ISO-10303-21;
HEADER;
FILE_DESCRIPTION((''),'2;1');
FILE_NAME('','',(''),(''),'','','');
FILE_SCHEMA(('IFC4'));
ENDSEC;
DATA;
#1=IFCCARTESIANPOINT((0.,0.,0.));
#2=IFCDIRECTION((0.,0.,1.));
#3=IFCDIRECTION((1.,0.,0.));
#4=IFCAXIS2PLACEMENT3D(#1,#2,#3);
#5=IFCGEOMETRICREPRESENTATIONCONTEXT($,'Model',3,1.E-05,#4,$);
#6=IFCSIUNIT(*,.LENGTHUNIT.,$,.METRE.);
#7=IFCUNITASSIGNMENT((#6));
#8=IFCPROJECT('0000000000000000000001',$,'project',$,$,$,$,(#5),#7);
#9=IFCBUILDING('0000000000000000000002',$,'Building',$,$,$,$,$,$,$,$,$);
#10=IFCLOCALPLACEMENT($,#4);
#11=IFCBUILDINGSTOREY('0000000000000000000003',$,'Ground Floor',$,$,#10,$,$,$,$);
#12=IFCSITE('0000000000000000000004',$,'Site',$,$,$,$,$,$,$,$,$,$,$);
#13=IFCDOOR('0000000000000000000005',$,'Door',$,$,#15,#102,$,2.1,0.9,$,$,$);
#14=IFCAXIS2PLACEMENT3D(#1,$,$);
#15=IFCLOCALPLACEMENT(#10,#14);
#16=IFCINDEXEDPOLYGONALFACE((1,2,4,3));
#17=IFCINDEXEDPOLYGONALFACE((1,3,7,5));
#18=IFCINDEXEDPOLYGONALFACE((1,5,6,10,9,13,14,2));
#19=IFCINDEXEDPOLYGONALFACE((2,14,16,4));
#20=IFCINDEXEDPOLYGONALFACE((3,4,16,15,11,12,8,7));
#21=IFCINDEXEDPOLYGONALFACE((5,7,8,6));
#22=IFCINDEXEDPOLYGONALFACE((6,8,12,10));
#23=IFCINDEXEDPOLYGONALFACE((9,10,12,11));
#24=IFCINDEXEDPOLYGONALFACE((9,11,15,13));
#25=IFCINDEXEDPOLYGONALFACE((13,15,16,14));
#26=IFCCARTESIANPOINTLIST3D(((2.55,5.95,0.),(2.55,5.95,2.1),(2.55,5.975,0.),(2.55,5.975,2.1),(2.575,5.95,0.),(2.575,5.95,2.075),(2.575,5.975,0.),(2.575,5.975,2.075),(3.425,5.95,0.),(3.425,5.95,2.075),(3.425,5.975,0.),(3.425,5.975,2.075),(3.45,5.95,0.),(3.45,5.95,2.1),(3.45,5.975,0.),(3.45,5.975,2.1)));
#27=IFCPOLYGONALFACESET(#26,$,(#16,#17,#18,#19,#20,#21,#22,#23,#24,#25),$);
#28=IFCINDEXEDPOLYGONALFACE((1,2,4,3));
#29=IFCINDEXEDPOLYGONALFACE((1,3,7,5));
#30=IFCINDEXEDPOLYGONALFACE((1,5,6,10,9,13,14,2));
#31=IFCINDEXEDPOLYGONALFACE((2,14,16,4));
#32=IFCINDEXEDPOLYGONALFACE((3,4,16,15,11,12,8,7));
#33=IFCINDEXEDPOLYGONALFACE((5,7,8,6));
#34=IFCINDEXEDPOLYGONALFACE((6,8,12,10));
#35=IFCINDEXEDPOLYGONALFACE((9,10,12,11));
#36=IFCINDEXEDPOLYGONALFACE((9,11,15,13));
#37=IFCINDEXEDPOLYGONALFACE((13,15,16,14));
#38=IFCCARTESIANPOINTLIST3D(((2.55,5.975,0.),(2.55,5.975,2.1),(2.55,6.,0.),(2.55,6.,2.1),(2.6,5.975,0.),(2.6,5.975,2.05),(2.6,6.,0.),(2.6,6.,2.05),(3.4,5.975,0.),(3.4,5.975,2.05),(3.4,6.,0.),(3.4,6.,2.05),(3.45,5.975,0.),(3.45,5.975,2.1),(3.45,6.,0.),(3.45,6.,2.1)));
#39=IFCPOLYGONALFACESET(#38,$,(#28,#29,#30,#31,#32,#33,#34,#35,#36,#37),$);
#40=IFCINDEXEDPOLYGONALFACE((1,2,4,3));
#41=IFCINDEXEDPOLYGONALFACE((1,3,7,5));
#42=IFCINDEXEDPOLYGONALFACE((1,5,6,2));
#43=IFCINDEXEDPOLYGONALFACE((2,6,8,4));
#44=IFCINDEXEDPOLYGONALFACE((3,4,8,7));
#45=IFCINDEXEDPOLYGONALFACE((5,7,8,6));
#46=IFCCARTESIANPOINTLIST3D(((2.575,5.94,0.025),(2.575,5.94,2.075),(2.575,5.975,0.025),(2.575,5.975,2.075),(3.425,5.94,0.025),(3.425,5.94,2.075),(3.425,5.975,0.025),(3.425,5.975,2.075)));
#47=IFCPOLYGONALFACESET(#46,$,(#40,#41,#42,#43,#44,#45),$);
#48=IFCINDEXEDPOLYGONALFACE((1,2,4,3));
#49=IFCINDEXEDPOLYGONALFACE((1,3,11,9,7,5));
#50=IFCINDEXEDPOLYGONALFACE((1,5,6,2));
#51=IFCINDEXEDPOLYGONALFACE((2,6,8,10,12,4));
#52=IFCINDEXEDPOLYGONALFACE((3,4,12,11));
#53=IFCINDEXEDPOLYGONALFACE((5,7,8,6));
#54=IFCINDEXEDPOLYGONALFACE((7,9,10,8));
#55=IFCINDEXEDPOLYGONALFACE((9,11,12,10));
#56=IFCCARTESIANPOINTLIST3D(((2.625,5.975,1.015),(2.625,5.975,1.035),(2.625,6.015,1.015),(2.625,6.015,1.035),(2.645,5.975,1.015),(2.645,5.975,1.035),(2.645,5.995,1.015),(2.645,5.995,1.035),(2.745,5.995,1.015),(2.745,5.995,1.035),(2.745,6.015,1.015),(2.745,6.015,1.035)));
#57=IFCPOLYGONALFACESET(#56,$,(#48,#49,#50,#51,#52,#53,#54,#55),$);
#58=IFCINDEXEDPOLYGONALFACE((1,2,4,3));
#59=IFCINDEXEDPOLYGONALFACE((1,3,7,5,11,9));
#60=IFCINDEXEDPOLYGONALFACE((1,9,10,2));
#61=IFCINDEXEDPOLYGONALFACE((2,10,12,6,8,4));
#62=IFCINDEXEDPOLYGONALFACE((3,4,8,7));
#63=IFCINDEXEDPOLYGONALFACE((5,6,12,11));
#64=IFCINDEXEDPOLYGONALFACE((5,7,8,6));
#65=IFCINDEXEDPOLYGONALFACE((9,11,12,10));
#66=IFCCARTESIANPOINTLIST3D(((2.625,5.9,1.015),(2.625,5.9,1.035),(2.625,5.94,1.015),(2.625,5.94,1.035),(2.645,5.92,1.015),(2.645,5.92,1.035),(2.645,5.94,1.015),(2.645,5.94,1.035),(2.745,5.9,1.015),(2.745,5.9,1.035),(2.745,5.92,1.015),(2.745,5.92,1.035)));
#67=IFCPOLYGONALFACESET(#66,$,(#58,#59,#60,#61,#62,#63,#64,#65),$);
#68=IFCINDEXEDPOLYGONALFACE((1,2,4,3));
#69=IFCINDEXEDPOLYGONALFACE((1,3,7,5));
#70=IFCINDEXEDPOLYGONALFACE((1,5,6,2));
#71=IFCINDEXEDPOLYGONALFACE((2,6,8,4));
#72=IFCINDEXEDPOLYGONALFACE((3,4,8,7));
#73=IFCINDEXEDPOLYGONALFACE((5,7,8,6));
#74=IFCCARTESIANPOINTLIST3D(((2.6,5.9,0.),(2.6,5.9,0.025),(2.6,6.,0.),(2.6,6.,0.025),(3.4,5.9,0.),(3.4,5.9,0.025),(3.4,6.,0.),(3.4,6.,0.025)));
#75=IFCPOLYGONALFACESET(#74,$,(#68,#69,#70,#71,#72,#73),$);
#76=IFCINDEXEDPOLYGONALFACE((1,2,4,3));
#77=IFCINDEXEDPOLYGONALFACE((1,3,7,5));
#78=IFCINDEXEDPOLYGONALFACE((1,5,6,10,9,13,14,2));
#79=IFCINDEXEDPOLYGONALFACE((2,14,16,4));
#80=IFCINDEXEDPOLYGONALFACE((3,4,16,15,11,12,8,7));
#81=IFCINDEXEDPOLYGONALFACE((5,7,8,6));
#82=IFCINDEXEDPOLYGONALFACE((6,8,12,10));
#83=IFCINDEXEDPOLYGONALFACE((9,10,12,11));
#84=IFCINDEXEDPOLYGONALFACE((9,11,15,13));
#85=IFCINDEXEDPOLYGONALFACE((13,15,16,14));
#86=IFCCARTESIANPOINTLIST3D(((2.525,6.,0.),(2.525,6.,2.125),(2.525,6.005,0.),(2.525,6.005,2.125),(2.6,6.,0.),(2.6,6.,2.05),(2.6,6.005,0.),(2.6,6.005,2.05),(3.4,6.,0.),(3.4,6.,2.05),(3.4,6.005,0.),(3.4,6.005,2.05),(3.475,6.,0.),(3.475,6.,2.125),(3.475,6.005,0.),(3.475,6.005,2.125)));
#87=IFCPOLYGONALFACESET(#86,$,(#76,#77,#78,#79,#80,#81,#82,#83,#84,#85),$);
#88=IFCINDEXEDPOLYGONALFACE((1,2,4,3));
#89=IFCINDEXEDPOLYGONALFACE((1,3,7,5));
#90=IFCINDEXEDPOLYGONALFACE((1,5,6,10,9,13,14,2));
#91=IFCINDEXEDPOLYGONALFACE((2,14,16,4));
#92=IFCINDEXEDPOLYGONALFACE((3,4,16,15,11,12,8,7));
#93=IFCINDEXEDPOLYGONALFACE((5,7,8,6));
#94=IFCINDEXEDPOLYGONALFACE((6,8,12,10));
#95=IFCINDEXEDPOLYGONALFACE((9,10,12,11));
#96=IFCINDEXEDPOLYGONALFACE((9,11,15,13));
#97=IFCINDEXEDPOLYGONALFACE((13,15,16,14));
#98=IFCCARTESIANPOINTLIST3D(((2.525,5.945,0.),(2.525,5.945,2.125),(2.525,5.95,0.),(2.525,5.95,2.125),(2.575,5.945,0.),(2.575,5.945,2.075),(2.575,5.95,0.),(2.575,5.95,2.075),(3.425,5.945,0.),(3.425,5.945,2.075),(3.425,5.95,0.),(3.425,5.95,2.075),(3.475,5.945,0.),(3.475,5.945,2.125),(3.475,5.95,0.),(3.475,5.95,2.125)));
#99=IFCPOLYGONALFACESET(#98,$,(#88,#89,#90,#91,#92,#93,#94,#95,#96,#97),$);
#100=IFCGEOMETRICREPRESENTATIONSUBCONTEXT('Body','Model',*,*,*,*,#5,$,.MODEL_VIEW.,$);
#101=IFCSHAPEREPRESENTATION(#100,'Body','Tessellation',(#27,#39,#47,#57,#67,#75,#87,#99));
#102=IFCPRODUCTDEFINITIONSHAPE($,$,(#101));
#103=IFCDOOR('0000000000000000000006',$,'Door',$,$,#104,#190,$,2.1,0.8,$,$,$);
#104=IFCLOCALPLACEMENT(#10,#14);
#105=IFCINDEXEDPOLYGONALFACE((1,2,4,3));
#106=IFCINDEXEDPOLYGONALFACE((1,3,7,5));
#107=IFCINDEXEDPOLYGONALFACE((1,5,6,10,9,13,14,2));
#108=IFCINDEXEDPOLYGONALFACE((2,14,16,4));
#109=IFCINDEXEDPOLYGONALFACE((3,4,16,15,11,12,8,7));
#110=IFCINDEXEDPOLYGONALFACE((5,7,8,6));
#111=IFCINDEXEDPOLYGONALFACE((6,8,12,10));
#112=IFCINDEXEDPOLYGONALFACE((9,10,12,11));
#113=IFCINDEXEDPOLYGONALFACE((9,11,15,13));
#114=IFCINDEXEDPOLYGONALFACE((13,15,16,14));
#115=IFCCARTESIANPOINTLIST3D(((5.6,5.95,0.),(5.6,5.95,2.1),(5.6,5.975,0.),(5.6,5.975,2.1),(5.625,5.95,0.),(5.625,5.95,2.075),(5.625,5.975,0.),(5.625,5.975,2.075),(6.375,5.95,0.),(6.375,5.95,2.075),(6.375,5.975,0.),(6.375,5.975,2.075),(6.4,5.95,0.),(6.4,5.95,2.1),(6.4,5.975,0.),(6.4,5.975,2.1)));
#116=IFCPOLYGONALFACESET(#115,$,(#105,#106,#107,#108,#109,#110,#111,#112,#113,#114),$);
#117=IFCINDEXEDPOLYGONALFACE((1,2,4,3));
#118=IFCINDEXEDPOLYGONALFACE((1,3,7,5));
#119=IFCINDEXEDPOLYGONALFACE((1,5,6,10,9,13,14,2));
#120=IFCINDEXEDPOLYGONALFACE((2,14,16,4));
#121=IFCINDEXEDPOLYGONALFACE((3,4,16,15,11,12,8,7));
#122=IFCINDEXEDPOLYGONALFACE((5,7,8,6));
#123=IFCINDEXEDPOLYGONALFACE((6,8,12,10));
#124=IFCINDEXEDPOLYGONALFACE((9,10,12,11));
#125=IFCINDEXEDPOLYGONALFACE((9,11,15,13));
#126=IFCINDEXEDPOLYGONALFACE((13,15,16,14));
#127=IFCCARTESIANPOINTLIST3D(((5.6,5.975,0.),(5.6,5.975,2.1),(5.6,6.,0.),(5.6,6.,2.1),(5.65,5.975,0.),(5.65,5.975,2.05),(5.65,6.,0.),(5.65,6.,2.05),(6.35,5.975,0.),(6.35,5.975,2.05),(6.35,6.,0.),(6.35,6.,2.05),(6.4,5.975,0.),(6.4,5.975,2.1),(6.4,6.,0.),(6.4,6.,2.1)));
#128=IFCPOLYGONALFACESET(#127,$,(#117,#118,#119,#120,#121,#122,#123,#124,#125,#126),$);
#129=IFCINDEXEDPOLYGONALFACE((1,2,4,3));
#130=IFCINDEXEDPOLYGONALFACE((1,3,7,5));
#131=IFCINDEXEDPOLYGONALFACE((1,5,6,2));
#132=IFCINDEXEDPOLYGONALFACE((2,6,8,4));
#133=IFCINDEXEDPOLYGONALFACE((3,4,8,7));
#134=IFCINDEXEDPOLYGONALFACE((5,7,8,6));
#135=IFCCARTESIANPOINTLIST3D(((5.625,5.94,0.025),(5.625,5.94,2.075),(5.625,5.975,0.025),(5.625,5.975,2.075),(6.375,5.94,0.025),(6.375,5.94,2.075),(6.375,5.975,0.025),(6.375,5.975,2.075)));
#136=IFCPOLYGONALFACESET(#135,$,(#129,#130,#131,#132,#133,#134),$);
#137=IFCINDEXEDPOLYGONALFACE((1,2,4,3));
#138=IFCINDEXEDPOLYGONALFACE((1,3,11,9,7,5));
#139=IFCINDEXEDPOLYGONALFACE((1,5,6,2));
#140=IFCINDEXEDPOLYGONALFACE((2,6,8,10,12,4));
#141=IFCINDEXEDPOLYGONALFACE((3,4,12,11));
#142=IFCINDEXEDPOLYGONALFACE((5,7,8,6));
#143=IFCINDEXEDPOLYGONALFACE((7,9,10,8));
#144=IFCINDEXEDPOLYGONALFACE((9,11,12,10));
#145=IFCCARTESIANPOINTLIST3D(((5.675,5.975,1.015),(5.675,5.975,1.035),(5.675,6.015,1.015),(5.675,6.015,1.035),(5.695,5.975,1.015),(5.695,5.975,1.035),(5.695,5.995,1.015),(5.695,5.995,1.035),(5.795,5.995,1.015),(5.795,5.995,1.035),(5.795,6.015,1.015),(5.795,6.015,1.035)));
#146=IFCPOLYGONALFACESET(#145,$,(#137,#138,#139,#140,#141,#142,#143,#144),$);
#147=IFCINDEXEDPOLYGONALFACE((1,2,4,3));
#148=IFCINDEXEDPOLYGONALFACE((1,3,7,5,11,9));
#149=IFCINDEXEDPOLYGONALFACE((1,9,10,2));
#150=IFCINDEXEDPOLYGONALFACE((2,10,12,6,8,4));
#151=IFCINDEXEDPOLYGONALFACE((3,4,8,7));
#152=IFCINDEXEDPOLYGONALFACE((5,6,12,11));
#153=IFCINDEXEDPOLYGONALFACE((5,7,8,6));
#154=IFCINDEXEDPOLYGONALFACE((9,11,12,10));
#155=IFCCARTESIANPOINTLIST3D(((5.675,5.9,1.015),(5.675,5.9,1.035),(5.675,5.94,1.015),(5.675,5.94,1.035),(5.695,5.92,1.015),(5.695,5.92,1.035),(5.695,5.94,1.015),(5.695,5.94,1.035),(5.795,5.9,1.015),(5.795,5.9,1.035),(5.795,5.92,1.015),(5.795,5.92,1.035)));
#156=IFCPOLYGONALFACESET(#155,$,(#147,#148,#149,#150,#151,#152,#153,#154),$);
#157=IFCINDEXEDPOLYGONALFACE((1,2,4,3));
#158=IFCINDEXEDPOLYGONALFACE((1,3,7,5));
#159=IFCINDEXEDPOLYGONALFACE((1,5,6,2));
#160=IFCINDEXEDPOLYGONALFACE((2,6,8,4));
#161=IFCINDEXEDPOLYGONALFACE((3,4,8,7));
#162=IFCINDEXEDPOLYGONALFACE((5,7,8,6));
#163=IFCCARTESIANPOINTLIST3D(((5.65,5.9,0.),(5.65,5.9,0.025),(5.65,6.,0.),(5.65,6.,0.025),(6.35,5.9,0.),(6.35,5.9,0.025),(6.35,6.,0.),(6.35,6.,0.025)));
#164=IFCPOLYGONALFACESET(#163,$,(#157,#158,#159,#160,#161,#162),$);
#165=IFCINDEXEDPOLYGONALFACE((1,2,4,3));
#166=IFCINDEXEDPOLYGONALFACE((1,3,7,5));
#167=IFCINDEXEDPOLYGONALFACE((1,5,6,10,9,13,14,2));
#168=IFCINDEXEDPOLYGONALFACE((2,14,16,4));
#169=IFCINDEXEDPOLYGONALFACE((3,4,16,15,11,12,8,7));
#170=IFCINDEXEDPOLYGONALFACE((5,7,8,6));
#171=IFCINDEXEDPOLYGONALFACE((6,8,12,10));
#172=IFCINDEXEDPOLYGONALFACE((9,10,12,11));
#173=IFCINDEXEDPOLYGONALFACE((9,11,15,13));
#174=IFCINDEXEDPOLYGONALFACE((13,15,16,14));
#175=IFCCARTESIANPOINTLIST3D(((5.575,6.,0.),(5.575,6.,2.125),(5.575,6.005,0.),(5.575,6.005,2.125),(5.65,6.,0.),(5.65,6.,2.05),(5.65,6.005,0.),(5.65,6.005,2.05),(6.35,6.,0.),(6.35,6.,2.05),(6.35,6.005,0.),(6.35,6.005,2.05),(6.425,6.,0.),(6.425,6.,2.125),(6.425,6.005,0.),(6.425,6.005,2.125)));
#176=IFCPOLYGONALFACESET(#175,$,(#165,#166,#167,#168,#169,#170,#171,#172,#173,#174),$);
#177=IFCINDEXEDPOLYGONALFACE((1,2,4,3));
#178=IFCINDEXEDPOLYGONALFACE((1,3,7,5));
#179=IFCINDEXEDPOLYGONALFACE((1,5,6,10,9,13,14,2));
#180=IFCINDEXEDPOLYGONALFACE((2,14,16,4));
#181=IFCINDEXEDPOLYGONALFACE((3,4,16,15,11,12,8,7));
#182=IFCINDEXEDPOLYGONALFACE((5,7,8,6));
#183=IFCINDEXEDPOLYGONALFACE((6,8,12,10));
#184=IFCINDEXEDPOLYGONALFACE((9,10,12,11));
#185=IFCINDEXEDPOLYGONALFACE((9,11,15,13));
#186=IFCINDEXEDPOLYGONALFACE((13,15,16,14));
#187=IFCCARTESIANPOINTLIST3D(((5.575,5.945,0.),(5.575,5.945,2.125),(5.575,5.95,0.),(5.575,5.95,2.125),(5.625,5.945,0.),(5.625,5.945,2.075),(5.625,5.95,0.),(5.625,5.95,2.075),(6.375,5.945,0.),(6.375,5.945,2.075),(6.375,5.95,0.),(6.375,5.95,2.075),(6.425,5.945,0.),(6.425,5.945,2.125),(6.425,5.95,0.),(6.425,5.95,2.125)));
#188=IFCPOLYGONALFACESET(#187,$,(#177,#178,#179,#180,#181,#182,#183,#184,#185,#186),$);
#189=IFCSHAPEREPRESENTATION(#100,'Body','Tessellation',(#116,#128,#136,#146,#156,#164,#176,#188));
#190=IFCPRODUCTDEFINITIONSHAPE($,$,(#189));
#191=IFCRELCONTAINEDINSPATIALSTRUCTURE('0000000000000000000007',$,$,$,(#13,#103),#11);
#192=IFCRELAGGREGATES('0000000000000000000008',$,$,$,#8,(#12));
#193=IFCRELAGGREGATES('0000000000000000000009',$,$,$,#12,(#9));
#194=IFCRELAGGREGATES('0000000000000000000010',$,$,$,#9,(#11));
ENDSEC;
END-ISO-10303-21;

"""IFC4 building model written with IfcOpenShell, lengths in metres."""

from ifc_helpers import new_model, si_unit, frame, origin_with_axes, place, context, subcontext, project, spatial, line, indexed_curve, outline, extrude, element, save


model = new_model("IFC4")

# Units and contexts
model_context = context("Model", 3, precision=1e-05, world=origin_with_axes())
body_context = subcontext(model_context, "Body", "Model", "MODEL_VIEW")
ifc_project = project(units=[si_unit("LENGTHUNIT", "METRE")], contexts=[model_context])

# Site, building, storey
site = spatial("IfcSite", under=ifc_project, Name="Site")
building = spatial("IfcBuilding", under=site, Name="Building")
storey_placement = place(None, origin_with_axes())
storey = spatial("IfcBuildingStorey", under=building, at=storey_placement, Name="Ground Floor")

# Doors
door_1_placement = place(storey_placement, frame((3.45, 6.0, 0.0), z_axis=(0.0, 0.0, 1.0), x_axis=(-1.0, 0.0, 0.0)))
element("IfcDoor", 1, at=door_1_placement, inside=storey, Name="Door", OverallHeight=2.1, OverallWidth=0.9, context=body_context, shape_type="SweptSolid", body=[
    extrude(outline(indexed_curve([(0.0, 0.0), (0.0, 2.1), (0.9, 2.1), (0.9, 0.0), (0.875, 0.0), (0.875, 2.075), (0.025, 2.075), (0.025, 0.0)], segments=[line(1, 2, 3, 4, 5, 6, 7, 8, 1)])), frame((0.0, 0.025, 0.0), z_axis=(0.0, -1.0, 0.0), x_axis=(1.0, 0.0, 0.0)), (0.0, 0.0, -1.0), 0.025),
    extrude(outline(indexed_curve([(0.0, 0.0), (0.0, 2.1), (0.9, 2.1), (0.9, 0.0), (0.85, 0.0), (0.85, 2.05), (0.05, 2.05), (0.05, 0.0)], segments=[line(1, 2, 3, 4, 5, 6, 7, 8, 1)])), frame((0.0, 0.0, 0.0), z_axis=(0.0, -1.0, 0.0), x_axis=(1.0, 0.0, 0.0)), (0.0, 0.0, -1.0), 0.025),
    extrude(outline(indexed_curve([(0.0, 0.0), (0.85, 0.0), (0.85, 0.035), (0.0, 0.035)], segments=[line(1, 2, 3, 4, 1)])), frame((0.025, 0.025, 0.025), z_axis=(0.0, 0.0, 1.0), x_axis=(1.0, 0.0, 0.0)), (0.0, 0.0, 1.0), 2.05),
    extrude(outline(indexed_curve([(0.0, 0.0), (0.0, -0.04), (-0.12, -0.04), (-0.12, -0.02), (-0.02, -0.02), (-0.02, 0.0)], segments=[line(1, 2, 3, 4, 5, 6, 1)])), frame((0.825, 0.025, 1.015), z_axis=(0.0, 0.0, 1.0), x_axis=(1.0, 0.0, 0.0)), (0.0, 0.0, 1.0), 0.02),
    extrude(outline(indexed_curve([(0.0, 0.0), (0.0, 0.04), (-0.12, 0.04), (-0.12, 0.02), (-0.02, 0.02), (-0.02, 0.0)], segments=[line(1, 2, 3, 4, 5, 6, 1)])), frame((0.825, 0.06, 1.015), z_axis=(0.0, 0.0, 1.0), x_axis=(1.0, 0.0, 0.0)), (0.0, 0.0, 1.0), 0.02),
    extrude(outline(indexed_curve([(0.0, 0.0), (0.8, 0.0), (0.8, 0.1), (0.0, 0.1)], segments=[line(1, 2, 3, 4, 1)])), frame((0.05, 0.0, 0.0), z_axis=(0.0, 0.0, 1.0), x_axis=(1.0, 0.0, 0.0)), (0.0, 0.0, 1.0), 0.025),
    extrude(outline(indexed_curve([(0.0, 0.0), (0.0, 2.125), (0.95, 2.125), (0.95, 0.0), (0.875, 0.0), (0.875, 2.05), (0.075, 2.05), (0.075, 0.0)], segments=[line(1, 2, 3, 4, 5, 6, 7, 8, 1)])), frame((-0.025, -0.005, 0.0), z_axis=(0.0, -1.0, 0.0), x_axis=(1.0, 0.0, 0.0)), (0.0, 0.0, -1.0), 0.005),
    extrude(outline(indexed_curve([(0.0, 0.0), (0.0, 2.125), (0.95, 2.125), (0.95, 0.0), (0.9, 0.0), (0.9, 2.075), (0.05, 2.075), (0.05, 0.0)], segments=[line(1, 2, 3, 4, 5, 6, 7, 8, 1)])), frame((-0.025, 0.05, 0.0), z_axis=(0.0, -1.0, 0.0), x_axis=(1.0, 0.0, 0.0)), (0.0, 0.0, -1.0), 0.005),
])
door_2_placement = place(storey_placement, frame((6.4, 6.0, 0.0), z_axis=(0.0, 0.0, 1.0), x_axis=(-1.0, 0.0, 0.0)))
element("IfcDoor", 2, at=door_2_placement, inside=storey, Name="Door", OverallHeight=2.1, OverallWidth=0.8, context=body_context, shape_type="SweptSolid", body=[
    extrude(outline(indexed_curve([(0.0, 0.0), (0.0, 2.1), (0.8, 2.1), (0.8, 0.0), (0.775, 0.0), (0.775, 2.075), (0.025, 2.075), (0.025, 0.0)], segments=[line(1, 2, 3, 4, 5, 6, 7, 8, 1)])), frame((0.0, 0.025, 0.0), z_axis=(0.0, -1.0, 0.0), x_axis=(1.0, 0.0, 0.0)), (0.0, 0.0, -1.0), 0.025),
    extrude(outline(indexed_curve([(0.0, 0.0), (0.0, 2.1), (0.8, 2.1), (0.8, 0.0), (0.75, 0.0), (0.75, 2.05), (0.05, 2.05), (0.05, 0.0)], segments=[line(1, 2, 3, 4, 5, 6, 7, 8, 1)])), frame((0.0, 0.0, 0.0), z_axis=(0.0, -1.0, 0.0), x_axis=(1.0, 0.0, 0.0)), (0.0, 0.0, -1.0), 0.025),
    extrude(outline(indexed_curve([(0.0, 0.0), (0.75, 0.0), (0.75, 0.035), (0.0, 0.035)], segments=[line(1, 2, 3, 4, 1)])), frame((0.025, 0.025, 0.025), z_axis=(0.0, 0.0, 1.0), x_axis=(1.0, 0.0, 0.0)), (0.0, 0.0, 1.0), 2.05),
    extrude(outline(indexed_curve([(0.0, 0.0), (0.0, -0.04), (-0.12, -0.04), (-0.12, -0.02), (-0.02, -0.02), (-0.02, 0.0)], segments=[line(1, 2, 3, 4, 5, 6, 1)])), frame((0.725, 0.025, 1.015), z_axis=(0.0, 0.0, 1.0), x_axis=(1.0, 0.0, 0.0)), (0.0, 0.0, 1.0), 0.02),
    extrude(outline(indexed_curve([(0.0, 0.0), (0.0, 0.04), (-0.12, 0.04), (-0.12, 0.02), (-0.02, 0.02), (-0.02, 0.0)], segments=[line(1, 2, 3, 4, 5, 6, 1)])), frame((0.725, 0.06, 1.015), z_axis=(0.0, 0.0, 1.0), x_axis=(1.0, 0.0, 0.0)), (0.0, 0.0, 1.0), 0.02),
    extrude(outline(indexed_curve([(0.0, 0.0), (0.7, 0.0), (0.7, 0.1), (0.0, 0.1)], segments=[line(1, 2, 3, 4, 1)])), frame((0.05, 0.0, 0.0), z_axis=(0.0, 0.0, 1.0), x_axis=(1.0, 0.0, 0.0)), (0.0, 0.0, 1.0), 0.025),
    extrude(outline(indexed_curve([(0.0, 0.0), (0.0, 2.125), (0.85, 2.125), (0.85, 0.0), (0.775, 0.0), (0.775, 2.05), (0.075, 2.05), (0.075, 0.0)], segments=[line(1, 2, 3, 4, 5, 6, 7, 8, 1)])), frame((-0.025, -0.005, 0.0), z_axis=(0.0, -1.0, 0.0), x_axis=(1.0, 0.0, 0.0)), (0.0, 0.0, -1.0), 0.005),
    extrude(outline(indexed_curve([(0.0, 0.0), (0.0, 2.125), (0.85, 2.125), (0.85, 0.0), (0.8, 0.0), (0.8, 2.075), (0.05, 2.075), (0.05, 0.0)], segments=[line(1, 2, 3, 4, 5, 6, 7, 8, 1)])), frame((-0.025, 0.05, 0.0), z_axis=(0.0, -1.0, 0.0), x_axis=(1.0, 0.0, 0.0)), (0.0, 0.0, -1.0), 0.005),
])

save(model, "model.ifc")
